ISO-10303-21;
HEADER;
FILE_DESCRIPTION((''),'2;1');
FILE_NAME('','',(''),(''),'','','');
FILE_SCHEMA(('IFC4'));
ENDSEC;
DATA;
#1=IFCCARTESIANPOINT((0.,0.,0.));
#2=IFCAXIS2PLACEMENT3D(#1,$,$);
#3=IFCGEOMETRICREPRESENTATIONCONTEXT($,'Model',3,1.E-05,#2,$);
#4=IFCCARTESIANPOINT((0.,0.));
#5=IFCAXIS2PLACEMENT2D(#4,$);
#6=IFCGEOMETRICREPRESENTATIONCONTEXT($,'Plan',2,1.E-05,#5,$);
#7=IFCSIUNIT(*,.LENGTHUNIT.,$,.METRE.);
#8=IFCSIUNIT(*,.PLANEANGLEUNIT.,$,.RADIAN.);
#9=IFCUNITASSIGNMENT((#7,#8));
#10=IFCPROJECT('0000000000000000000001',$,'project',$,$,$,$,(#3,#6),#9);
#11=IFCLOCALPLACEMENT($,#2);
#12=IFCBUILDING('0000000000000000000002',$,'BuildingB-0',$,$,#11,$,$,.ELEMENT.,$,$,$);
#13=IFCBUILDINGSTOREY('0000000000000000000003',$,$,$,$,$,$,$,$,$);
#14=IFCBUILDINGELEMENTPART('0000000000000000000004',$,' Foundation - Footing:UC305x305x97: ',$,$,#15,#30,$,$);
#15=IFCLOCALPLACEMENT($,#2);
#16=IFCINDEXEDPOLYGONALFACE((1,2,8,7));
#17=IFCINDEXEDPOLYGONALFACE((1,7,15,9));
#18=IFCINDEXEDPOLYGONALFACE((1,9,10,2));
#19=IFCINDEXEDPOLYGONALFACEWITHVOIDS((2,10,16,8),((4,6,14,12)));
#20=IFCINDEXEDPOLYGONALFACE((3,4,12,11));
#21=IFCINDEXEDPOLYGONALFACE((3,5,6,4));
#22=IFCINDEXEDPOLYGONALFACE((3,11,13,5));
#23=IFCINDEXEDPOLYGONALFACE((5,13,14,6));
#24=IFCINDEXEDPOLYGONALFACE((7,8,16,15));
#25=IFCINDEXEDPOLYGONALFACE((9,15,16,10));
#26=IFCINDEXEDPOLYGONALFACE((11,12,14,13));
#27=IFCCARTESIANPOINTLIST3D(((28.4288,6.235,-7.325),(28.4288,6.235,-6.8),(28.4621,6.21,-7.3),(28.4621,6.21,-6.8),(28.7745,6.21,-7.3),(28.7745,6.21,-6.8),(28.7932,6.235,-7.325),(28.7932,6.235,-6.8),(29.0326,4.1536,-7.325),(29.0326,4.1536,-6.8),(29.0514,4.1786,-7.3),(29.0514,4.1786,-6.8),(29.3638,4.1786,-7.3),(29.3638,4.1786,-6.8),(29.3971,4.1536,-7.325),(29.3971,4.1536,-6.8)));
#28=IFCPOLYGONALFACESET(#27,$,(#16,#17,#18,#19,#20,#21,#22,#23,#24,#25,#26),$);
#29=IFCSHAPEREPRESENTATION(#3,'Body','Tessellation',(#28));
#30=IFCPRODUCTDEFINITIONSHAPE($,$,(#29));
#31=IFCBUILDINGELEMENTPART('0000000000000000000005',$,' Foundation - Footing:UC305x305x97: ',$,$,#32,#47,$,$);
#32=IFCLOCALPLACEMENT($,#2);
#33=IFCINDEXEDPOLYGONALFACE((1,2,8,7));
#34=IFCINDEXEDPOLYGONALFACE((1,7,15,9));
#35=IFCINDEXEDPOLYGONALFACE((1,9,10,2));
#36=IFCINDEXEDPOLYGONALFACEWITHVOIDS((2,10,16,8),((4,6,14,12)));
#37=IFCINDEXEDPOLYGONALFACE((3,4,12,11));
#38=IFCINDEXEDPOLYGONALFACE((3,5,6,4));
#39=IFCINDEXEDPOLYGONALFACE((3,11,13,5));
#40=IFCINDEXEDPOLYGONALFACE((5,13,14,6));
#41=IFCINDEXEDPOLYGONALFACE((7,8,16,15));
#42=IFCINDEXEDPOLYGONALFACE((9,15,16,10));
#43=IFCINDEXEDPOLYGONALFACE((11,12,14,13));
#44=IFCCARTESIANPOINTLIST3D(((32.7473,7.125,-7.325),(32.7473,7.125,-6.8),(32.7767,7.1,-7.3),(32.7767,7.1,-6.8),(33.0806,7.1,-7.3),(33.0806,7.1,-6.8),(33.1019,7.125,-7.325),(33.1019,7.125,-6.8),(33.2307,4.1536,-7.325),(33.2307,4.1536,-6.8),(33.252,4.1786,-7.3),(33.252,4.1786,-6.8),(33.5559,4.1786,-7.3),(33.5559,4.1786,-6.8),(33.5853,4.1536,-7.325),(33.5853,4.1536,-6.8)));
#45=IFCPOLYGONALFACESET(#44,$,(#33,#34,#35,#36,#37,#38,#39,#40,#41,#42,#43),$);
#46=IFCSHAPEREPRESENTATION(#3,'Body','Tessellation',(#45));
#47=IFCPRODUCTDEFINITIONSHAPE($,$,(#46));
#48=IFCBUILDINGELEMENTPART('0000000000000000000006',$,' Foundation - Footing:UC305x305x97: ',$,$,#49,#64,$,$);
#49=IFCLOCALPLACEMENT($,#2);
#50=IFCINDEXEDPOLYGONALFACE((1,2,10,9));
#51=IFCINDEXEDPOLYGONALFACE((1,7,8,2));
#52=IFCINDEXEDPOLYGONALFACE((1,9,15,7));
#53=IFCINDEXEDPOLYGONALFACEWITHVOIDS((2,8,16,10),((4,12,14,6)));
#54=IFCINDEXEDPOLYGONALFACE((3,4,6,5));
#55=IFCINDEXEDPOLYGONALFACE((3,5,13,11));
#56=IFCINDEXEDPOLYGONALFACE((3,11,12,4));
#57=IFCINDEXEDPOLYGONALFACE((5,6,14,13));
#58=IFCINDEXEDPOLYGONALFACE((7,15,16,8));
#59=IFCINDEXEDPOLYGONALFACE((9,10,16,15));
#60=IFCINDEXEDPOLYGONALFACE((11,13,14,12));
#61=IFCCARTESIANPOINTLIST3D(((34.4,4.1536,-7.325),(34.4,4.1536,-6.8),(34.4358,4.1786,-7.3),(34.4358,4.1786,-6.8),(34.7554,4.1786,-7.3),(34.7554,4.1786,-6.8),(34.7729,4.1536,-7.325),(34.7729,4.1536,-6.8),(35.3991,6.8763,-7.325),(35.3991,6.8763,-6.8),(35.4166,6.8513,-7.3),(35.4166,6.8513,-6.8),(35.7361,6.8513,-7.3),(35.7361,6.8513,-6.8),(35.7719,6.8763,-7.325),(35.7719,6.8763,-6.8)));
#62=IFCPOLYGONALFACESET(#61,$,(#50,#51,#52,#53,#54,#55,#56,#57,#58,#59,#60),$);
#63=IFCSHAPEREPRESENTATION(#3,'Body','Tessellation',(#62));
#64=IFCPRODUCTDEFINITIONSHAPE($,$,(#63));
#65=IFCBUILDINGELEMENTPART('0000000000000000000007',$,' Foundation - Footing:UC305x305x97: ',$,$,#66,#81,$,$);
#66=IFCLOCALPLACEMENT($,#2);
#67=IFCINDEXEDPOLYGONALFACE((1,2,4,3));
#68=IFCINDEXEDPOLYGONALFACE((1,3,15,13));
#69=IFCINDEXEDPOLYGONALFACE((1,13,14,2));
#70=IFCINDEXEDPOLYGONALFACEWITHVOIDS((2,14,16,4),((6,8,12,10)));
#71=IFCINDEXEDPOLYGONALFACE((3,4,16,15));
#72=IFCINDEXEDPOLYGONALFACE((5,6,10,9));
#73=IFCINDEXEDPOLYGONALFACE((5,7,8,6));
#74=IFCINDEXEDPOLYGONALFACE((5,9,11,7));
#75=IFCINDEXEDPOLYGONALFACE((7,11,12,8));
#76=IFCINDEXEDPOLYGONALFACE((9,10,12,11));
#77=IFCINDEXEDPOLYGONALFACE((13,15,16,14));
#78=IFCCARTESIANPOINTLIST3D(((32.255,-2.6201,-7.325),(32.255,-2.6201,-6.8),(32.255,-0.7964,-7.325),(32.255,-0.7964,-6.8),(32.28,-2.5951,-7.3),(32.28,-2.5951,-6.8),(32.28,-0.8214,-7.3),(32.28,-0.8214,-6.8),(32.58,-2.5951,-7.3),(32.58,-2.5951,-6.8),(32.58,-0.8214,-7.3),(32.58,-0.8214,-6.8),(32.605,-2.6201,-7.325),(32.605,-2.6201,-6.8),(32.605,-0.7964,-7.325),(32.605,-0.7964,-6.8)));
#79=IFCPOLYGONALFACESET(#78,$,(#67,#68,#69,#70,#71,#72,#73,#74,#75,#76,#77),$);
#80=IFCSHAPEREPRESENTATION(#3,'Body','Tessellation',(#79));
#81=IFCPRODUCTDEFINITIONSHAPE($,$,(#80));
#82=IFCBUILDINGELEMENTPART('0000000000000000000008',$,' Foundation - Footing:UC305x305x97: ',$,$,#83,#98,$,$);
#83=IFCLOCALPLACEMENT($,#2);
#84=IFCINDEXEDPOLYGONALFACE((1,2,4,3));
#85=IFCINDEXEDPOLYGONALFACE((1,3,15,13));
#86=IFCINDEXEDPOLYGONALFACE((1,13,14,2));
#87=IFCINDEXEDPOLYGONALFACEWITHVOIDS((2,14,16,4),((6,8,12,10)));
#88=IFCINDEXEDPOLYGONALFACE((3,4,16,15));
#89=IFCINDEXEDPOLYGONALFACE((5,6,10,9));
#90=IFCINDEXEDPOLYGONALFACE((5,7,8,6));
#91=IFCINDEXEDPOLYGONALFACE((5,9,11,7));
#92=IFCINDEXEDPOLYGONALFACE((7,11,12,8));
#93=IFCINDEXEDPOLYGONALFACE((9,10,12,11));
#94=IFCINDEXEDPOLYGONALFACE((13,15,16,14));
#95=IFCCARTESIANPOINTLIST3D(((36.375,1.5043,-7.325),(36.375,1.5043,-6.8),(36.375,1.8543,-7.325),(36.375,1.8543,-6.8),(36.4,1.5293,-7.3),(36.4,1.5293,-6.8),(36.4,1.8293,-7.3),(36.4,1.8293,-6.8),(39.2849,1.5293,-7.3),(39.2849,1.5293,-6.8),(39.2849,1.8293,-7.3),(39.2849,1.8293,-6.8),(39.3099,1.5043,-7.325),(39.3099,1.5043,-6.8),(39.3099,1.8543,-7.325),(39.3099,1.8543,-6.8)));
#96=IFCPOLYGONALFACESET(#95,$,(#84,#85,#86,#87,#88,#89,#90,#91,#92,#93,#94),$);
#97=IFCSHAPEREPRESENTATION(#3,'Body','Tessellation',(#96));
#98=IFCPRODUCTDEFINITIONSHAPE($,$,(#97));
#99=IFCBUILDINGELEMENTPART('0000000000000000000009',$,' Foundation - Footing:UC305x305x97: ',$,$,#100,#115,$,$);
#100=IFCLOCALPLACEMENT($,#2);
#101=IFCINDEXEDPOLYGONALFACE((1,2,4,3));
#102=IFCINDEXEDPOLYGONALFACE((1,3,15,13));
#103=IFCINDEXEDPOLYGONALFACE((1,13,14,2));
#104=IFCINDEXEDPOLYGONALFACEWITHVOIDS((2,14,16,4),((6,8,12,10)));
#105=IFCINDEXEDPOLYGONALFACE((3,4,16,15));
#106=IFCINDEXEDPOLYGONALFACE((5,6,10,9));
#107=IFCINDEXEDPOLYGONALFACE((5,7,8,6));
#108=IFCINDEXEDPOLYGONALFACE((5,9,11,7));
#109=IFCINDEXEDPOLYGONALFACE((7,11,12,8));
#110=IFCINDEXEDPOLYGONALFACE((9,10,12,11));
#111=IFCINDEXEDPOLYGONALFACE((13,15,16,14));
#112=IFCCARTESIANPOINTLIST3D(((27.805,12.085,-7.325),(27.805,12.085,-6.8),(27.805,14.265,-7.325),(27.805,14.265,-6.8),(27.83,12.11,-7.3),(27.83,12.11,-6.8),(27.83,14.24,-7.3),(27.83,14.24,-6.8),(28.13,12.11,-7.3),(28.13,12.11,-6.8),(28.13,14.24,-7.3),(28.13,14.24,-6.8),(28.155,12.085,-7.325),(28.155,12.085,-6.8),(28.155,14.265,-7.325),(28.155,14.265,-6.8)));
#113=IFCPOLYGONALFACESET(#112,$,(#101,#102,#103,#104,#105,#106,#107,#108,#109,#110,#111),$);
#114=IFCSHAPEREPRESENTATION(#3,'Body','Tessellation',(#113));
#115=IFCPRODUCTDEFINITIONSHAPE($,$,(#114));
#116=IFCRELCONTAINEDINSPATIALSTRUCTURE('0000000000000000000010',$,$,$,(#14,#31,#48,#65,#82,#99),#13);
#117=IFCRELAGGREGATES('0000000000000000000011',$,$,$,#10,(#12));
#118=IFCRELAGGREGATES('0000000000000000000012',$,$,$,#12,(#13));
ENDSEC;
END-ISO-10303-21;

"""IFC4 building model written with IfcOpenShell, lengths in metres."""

from ifc_helpers import new_model, si_unit, origin, origin_2d, place, context, project, spatial, polyline, outline, extrude, element, save


model = new_model("IFC4")

# Units and contexts
model_context = context("Model", 3, precision=1e-05, world=origin())
plan_context = context("Plan", 2, precision=1e-05, world=origin_2d())
ifc_project = project(units=[si_unit("LENGTHUNIT", "METRE"), si_unit("PLANEANGLEUNIT", "RADIAN")], contexts=[model_context, plan_context])

# Building, storey
building_placement = place(None, origin())
building = spatial("IfcBuilding", under=ifc_project, at=building_placement, Name="BuildingB-0", CompositionType="ELEMENT")
storey = spatial("IfcBuildingStorey", under=building)

# Building element parts, openings
building_element_part_1 = element("IfcBuildingElementPart", 1, inside=storey, Name=" Foundation - Footing:UC305x305x97: ", context=model_context, shape_type="SweptSolid", body=[
    extrude(outline(polyline([(29.0326, 4.1536, -7.325), (29.3971, 4.1536, -7.325), (28.7932, 6.235, -7.325), (28.4288, 6.235, -7.325), (29.0326, 4.1536, -7.325)])), None, (0.0, 0.0, 1.0), 0.525),
])
element("IfcOpeningElement", 2, inside=storey, cuts=building_element_part_1, context=model_context, shape_type="SweptSolid", body=[
    extrude(outline(polyline([(29.0514, 4.1786, -7.3), (29.3638, 4.1786, -7.3), (28.7745, 6.21, -7.3), (28.4621, 6.21, -7.3), (29.0514, 4.1786, -7.3)])), None, (0.0, 0.0, 1.0), 0.5),
])
building_element_part_2 = element("IfcBuildingElementPart", 3, inside=storey, Name=" Foundation - Footing:UC305x305x97: ", context=model_context, shape_type="SweptSolid", body=[
    extrude(outline(polyline([(33.2307, 4.1536, -7.325), (33.5853, 4.1536, -7.325), (33.1019, 7.125, -7.325), (32.7473, 7.125, -7.325), (33.2307, 4.1536, -7.325)])), None, (0.0, 0.0, 1.0), 0.525),
])
element("IfcOpeningElement", 4, inside=storey, cuts=building_element_part_2, context=model_context, shape_type="SweptSolid", body=[
    extrude(outline(polyline([(33.252, 4.1786, -7.3), (33.5559, 4.1786, -7.3), (33.0806, 7.1, -7.3), (32.7767, 7.1, -7.3), (33.252, 4.1786, -7.3)])), None, (0.0, 0.0, 1.0), 0.5),
])
building_element_part_3 = element("IfcBuildingElementPart", 5, inside=storey, Name=" Foundation - Footing:UC305x305x97: ", context=model_context, shape_type="SweptSolid", body=[
    extrude(outline(polyline([(34.4, 4.1536, -7.325), (34.7729, 4.1536, -7.325), (35.7719, 6.8763, -7.325), (35.3991, 6.8763, -7.325), (34.4, 4.1536, -7.325)])), None, (0.0, 0.0, 1.0), 0.525),
])
element("IfcOpeningElement", 6, inside=storey, cuts=building_element_part_3, context=model_context, shape_type="SweptSolid", body=[
    extrude(outline(polyline([(34.4358, 4.1786, -7.3), (34.7554, 4.1786, -7.3), (35.7361, 6.8513, -7.3), (35.4166, 6.8513, -7.3), (34.4358, 4.1786, -7.3)])), None, (0.0, 0.0, 1.0), 0.5),
])
building_element_part_4 = element("IfcBuildingElementPart", 7, inside=storey, Name=" Foundation - Footing:UC305x305x97: ", context=model_context, shape_type="SweptSolid", body=[
    extrude(outline(polyline([(32.255, -2.6201, -7.325), (32.605, -2.6201, -7.325), (32.605, -0.7964, -7.325), (32.255, -0.7964, -7.325), (32.255, -2.6201, -7.325)])), None, (0.0, 0.0, 1.0), 0.525),
])
element("IfcOpeningElement", 8, inside=storey, cuts=building_element_part_4, context=model_context, shape_type="SweptSolid", body=[
    extrude(outline(polyline([(32.28, -2.5951, -7.3), (32.58, -2.5951, -7.3), (32.58, -0.8214, -7.3), (32.28, -0.8214, -7.3), (32.28, -2.5951, -7.3)])), None, (0.0, 0.0, 1.0), 0.5),
])
building_element_part_5 = element("IfcBuildingElementPart", 9, inside=storey, Name=" Foundation - Footing:UC305x305x97: ", context=model_context, shape_type="SweptSolid", body=[
    extrude(outline(polyline([(36.375, 1.5043, -7.325), (36.375, 1.8543, -7.325), (39.3099, 1.8543, -7.325), (39.3099, 1.5043, -7.325), (36.375, 1.5043, -7.325)])), None, (0.0, 0.0, 1.0), 0.525),
])
element("IfcOpeningElement", 10, inside=storey, cuts=building_element_part_5, context=model_context, shape_type="SweptSolid", body=[
    extrude(outline(polyline([(36.4, 1.5293, -7.3), (36.4, 1.8293, -7.3), (39.2849, 1.8293, -7.3), (39.2849, 1.5293, -7.3), (36.4, 1.5293, -7.3)])), None, (0.0, 0.0, 1.0), 0.5),
])
building_element_part_6 = element("IfcBuildingElementPart", 11, inside=storey, Name=" Foundation - Footing:UC305x305x97: ", context=model_context, shape_type="SweptSolid", body=[
    extrude(outline(polyline([(27.805, 12.085, -7.325), (28.155, 12.085, -7.325), (28.155, 14.265, -7.325), (27.805, 14.265, -7.325), (27.805, 12.085, -7.325)])), None, (0.0, 0.0, 1.0), 0.525),
])
element("IfcOpeningElement", 12, inside=storey, cuts=building_element_part_6, context=model_context, shape_type="SweptSolid", body=[
    extrude(outline(polyline([(27.83, 12.11, -7.3), (28.13, 12.11, -7.3), (28.13, 14.24, -7.3), (27.83, 14.24, -7.3), (27.83, 12.11, -7.3)])), None, (0.0, 0.0, 1.0), 0.5),
])

save(model, "model.ifc")
